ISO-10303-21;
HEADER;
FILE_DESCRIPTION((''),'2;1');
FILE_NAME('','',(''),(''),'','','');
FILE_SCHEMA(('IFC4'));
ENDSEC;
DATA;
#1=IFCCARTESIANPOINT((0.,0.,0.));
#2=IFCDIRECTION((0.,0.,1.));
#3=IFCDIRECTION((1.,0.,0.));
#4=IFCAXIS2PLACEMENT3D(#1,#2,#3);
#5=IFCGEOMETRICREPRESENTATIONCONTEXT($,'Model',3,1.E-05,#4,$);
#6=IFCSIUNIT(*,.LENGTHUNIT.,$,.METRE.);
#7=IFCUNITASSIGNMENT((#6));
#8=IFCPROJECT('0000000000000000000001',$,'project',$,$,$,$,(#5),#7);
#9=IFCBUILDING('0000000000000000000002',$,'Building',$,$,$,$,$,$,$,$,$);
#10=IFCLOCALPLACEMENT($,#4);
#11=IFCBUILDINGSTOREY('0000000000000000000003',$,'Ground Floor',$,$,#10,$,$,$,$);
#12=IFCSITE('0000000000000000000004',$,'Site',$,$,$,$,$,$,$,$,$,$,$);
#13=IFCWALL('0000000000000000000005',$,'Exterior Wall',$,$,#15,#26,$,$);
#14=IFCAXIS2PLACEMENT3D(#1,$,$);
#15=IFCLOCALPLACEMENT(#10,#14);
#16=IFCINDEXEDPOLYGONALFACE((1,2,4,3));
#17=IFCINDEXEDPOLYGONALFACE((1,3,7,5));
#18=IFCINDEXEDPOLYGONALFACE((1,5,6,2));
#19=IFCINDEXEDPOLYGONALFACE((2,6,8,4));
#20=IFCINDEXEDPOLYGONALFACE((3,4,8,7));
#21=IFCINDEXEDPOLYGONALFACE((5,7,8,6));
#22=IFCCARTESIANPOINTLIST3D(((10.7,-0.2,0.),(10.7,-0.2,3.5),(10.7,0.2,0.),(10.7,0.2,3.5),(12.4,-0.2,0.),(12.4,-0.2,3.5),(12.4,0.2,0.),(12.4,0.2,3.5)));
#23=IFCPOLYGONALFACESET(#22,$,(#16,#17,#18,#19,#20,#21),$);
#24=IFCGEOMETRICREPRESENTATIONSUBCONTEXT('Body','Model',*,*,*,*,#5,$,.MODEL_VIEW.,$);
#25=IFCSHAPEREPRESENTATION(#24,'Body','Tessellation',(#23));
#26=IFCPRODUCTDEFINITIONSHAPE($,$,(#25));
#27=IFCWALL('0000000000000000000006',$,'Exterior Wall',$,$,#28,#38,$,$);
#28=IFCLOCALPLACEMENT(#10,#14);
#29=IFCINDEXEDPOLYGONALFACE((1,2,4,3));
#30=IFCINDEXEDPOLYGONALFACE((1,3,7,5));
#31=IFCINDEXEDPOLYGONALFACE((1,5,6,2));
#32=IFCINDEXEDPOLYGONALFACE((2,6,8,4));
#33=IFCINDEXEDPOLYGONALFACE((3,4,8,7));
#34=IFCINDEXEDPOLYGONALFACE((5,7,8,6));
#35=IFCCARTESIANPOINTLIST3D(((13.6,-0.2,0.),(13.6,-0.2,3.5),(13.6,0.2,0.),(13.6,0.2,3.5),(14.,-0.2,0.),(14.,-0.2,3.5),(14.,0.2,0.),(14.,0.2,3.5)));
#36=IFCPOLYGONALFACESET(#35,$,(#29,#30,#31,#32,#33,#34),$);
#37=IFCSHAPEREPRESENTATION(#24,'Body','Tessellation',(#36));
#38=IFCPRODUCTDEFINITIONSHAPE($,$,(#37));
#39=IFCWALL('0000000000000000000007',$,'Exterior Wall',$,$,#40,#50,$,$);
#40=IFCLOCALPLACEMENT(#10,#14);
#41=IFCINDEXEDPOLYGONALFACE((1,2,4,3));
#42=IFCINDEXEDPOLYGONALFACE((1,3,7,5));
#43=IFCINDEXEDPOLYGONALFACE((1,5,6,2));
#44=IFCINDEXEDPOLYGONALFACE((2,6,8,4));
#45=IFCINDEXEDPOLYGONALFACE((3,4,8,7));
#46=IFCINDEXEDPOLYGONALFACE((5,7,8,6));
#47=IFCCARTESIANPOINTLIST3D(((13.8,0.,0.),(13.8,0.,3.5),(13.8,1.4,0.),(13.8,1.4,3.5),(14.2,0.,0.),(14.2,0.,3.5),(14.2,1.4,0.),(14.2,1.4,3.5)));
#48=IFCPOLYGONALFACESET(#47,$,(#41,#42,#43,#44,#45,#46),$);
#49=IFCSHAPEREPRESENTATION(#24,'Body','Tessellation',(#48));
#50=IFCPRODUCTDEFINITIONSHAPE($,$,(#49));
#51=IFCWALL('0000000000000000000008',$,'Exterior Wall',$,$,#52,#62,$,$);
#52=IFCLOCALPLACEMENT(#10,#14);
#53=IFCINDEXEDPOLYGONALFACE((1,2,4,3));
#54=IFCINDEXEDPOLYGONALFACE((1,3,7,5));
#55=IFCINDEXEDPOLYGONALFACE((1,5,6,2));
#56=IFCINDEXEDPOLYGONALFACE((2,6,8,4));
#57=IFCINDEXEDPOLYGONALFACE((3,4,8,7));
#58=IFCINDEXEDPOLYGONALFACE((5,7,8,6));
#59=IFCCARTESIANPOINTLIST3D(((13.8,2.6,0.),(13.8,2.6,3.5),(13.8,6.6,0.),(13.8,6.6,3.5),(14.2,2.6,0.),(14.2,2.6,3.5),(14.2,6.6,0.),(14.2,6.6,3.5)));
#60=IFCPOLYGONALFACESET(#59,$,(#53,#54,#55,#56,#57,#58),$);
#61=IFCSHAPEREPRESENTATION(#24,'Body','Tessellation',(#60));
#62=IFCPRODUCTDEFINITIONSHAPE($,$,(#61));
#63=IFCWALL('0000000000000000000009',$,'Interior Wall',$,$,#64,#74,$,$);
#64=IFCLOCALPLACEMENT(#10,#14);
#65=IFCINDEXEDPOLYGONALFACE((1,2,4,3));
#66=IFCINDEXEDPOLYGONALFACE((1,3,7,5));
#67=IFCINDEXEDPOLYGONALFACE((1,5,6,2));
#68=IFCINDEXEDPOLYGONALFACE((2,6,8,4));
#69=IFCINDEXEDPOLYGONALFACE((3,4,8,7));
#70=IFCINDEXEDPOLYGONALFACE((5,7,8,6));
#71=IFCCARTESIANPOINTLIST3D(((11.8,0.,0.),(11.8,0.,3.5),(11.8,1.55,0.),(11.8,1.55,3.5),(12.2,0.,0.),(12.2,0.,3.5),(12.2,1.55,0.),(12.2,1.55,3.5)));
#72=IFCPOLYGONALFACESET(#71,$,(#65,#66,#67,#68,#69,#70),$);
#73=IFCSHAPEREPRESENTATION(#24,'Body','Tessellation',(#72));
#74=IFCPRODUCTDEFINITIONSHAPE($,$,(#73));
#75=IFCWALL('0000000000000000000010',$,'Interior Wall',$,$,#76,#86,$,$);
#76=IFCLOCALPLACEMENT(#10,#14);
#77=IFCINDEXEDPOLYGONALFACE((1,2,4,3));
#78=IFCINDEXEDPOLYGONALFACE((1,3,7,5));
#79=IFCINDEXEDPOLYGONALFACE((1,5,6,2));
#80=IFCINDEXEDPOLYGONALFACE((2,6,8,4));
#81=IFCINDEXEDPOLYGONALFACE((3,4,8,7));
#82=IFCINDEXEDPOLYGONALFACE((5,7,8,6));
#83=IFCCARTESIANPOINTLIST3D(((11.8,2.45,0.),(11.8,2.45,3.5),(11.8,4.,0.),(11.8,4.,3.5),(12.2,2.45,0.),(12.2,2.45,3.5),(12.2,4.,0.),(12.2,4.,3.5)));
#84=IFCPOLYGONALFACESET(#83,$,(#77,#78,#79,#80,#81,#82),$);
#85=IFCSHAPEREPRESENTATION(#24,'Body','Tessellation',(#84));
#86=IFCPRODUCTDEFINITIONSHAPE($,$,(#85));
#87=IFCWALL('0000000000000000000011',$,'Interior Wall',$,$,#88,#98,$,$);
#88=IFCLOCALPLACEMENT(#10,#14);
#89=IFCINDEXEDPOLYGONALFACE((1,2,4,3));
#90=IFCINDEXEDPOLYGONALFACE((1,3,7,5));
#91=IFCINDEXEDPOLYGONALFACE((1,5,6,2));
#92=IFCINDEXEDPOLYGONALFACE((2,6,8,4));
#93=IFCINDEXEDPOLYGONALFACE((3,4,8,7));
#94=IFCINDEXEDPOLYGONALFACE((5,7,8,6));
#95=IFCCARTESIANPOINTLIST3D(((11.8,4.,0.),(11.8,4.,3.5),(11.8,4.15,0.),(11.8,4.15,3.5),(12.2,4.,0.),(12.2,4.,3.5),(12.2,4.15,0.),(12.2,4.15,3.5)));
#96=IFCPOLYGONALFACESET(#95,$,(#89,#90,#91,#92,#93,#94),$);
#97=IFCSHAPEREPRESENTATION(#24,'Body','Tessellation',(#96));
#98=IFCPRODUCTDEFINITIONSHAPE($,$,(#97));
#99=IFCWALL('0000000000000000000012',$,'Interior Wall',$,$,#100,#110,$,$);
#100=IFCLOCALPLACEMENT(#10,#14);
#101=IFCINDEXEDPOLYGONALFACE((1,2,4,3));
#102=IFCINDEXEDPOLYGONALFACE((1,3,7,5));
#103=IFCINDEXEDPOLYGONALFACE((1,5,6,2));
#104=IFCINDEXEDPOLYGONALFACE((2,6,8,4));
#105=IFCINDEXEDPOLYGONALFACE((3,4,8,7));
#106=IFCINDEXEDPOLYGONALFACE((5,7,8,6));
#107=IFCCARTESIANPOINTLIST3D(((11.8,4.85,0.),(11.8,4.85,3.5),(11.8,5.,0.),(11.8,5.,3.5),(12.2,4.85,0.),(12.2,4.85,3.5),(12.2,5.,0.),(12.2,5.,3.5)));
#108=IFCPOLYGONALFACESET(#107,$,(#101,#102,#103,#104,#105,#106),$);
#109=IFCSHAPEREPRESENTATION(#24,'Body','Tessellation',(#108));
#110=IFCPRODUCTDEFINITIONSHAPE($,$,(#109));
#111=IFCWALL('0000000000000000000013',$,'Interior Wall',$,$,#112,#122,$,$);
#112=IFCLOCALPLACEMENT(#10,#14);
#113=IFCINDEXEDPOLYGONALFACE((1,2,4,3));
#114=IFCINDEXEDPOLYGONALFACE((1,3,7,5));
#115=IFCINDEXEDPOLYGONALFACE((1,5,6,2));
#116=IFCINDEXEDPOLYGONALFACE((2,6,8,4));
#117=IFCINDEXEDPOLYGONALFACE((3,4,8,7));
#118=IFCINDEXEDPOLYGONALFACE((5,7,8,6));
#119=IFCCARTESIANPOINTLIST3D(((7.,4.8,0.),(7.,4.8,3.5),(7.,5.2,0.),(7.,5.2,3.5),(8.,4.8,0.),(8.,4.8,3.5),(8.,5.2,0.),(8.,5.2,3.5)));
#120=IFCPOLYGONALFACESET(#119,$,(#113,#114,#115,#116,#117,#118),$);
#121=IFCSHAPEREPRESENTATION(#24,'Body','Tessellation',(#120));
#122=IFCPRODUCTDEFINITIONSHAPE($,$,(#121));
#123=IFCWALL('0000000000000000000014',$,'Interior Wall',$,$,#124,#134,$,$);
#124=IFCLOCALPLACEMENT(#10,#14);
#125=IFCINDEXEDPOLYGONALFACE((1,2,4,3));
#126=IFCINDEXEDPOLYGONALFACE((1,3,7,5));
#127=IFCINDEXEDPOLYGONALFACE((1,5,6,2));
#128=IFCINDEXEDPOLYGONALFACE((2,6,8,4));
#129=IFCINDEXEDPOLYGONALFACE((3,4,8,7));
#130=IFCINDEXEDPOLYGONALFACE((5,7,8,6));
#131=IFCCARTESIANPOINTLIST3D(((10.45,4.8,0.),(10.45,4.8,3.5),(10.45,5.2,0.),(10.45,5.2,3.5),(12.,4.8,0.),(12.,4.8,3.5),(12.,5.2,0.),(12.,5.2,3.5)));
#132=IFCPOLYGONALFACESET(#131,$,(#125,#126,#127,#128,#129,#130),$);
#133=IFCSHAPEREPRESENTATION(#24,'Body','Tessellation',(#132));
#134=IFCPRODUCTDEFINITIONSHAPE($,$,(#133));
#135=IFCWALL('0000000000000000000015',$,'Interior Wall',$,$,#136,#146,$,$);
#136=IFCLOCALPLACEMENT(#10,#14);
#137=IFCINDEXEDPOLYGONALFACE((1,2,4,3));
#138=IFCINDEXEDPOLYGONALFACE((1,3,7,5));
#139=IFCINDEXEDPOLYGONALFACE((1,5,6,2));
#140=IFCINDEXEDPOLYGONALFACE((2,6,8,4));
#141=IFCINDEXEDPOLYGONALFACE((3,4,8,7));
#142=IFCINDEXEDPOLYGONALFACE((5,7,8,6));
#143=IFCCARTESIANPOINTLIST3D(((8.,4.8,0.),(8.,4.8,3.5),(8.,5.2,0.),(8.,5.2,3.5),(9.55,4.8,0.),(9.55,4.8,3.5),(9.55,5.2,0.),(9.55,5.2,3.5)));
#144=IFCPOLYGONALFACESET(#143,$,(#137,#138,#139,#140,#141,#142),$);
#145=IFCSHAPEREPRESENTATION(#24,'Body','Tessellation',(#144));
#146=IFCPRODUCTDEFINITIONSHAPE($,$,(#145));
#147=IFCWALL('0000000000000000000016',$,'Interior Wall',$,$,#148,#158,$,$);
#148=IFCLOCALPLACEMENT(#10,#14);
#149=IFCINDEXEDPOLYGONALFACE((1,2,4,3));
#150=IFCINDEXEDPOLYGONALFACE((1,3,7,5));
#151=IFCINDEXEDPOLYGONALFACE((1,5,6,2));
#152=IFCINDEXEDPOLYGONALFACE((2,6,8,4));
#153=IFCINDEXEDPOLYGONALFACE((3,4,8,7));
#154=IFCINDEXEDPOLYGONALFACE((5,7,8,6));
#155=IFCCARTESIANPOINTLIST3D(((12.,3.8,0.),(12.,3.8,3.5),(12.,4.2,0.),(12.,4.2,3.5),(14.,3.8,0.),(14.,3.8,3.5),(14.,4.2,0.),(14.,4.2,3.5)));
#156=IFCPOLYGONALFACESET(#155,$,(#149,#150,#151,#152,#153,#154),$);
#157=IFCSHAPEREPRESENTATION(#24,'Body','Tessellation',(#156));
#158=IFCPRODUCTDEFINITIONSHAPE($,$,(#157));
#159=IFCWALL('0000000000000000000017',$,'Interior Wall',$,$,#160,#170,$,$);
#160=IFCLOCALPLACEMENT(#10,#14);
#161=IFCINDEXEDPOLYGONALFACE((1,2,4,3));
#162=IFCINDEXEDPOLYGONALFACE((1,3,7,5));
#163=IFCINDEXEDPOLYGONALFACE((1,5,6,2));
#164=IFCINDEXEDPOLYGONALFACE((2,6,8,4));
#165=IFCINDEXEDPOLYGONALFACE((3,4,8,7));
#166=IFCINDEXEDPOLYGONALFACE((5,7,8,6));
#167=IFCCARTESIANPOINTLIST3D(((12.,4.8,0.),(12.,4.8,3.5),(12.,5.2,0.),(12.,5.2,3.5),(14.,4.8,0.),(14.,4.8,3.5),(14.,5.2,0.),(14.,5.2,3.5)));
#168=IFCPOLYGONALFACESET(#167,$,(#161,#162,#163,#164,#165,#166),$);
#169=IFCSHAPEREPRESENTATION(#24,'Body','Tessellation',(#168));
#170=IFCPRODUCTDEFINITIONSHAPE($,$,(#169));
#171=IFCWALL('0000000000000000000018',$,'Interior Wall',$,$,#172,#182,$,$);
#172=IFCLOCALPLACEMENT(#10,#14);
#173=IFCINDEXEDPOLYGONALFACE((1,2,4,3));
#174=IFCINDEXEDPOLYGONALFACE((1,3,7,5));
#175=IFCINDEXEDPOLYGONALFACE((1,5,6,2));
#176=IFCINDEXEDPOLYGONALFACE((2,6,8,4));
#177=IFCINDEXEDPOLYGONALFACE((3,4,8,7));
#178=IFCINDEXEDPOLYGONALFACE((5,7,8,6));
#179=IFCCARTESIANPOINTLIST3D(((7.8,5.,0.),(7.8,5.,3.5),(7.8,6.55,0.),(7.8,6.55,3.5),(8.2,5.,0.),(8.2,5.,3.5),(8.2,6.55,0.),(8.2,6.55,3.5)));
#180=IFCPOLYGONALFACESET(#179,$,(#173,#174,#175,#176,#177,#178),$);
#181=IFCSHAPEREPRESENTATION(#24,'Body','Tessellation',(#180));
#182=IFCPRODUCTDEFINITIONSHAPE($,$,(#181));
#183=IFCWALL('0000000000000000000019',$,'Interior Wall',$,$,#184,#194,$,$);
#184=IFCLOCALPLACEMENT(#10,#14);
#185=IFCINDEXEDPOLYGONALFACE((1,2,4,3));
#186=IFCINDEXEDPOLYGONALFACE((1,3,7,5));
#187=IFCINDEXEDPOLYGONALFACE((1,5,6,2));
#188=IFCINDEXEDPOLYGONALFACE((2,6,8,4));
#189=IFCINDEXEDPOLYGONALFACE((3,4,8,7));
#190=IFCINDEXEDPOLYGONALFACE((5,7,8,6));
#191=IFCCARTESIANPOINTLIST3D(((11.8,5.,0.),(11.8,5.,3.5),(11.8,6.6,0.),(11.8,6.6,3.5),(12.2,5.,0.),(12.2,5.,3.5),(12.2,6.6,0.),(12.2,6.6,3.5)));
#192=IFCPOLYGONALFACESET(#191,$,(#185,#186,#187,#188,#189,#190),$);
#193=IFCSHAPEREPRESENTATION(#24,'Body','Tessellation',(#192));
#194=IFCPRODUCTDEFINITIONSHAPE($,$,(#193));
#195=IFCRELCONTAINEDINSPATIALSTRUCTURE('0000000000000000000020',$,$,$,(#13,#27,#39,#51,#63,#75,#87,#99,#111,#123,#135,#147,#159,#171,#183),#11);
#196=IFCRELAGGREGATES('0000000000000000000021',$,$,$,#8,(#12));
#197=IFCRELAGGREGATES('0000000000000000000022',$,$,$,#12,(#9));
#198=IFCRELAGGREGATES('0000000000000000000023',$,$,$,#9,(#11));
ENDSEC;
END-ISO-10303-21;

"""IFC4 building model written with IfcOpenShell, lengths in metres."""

from ifc_helpers import new_model, si_unit, frame, origin_with_axes, place, context, subcontext, project, spatial, indexed_curve, outline, extrude, element, save


model = new_model("IFC4")

# Units and contexts
model_context = context("Model", 3, precision=1e-05, world=origin_with_axes())
body_context = subcontext(model_context, "Body", "Model", "MODEL_VIEW")
ifc_project = project(units=[si_unit("LENGTHUNIT", "METRE")], contexts=[model_context])

# Site, building, storey
site = spatial("IfcSite", under=ifc_project, Name="Site")
building = spatial("IfcBuilding", under=site, Name="Building")
storey_placement = place(None, origin_with_axes())
storey = spatial("IfcBuildingStorey", under=building, at=storey_placement, Name="Ground Floor")

# Walls
wall_1_placement = place(storey_placement, frame((10.7, 0.0, 0.0), z_axis=(0.0, 0.0, 1.0), x_axis=(1.0, 0.0, 0.0)))
element("IfcWall", 1, at=wall_1_placement, inside=storey, Name="Exterior Wall", context=body_context, shape_type="SweptSolid", body=[
    extrude(outline(indexed_curve([(0.0, 0.0), (0.0, 0.4), (1.7, 0.4), (1.7, 0.0), (0.0, 0.0)], self_intersect=False)), frame((0.0, -0.2, 0.0), z_axis=(0.0, 0.0, 1.0), x_axis=(1.0, 0.0, 0.0)), (0.0, 0.0, 1.0), 3.5),
])
wall_2_placement = place(storey_placement, frame((13.6, 0.0, 0.0), z_axis=(0.0, 0.0, 1.0), x_axis=(1.0, 0.0, 0.0)))
element("IfcWall", 2, at=wall_2_placement, inside=storey, Name="Exterior Wall", context=body_context, shape_type="SweptSolid", body=[
    extrude(outline(indexed_curve([(0.0, 0.0), (0.0, 0.4), (0.4, 0.4), (0.4, 0.0), (0.0, 0.0)], self_intersect=False)), frame((0.0, -0.2, 0.0), z_axis=(0.0, 0.0, 1.0), x_axis=(1.0, 0.0, 0.0)), (0.0, 0.0, 1.0), 3.5),
])
wall_3_placement = place(storey_placement, frame((14.0, 0.0, 0.0), z_axis=(0.0, 0.0, 1.0), x_axis=(0.0, 1.0, 0.0)))
element("IfcWall", 3, at=wall_3_placement, inside=storey, Name="Exterior Wall", context=body_context, shape_type="SweptSolid", body=[
    extrude(outline(indexed_curve([(0.0, 0.0), (0.0, 0.4), (1.4, 0.4), (1.4, 0.0), (0.0, 0.0)], self_intersect=False)), frame((0.0, -0.2, 0.0), z_axis=(0.0, 0.0, 1.0), x_axis=(1.0, 0.0, 0.0)), (0.0, 0.0, 1.0), 3.5),
])
wall_4_placement = place(storey_placement, frame((14.0, 2.6, 0.0), z_axis=(0.0, 0.0, 1.0), x_axis=(0.0, 1.0, 0.0)))
element("IfcWall", 4, at=wall_4_placement, inside=storey, Name="Exterior Wall", context=body_context, shape_type="SweptSolid", body=[
    extrude(outline(indexed_curve([(0.0, 0.0), (0.0, 0.4), (4.0, 0.4), (4.0, 0.0), (0.0, 0.0)], self_intersect=False)), frame((0.0, -0.2, 0.0), z_axis=(0.0, 0.0, 1.0), x_axis=(1.0, 0.0, 0.0)), (0.0, 0.0, 1.0), 3.5),
])
wall_5_placement = place(storey_placement, frame((12.0, 0.0, 0.0), z_axis=(0.0, 0.0, 1.0), x_axis=(0.0, 1.0, 0.0)))
element("IfcWall", 5, at=wall_5_placement, inside=storey, Name="Interior Wall", context=body_context, shape_type="SweptSolid", body=[
    extrude(outline(indexed_curve([(0.0, 0.0), (0.0, 0.4), (1.55, 0.4), (1.55, 0.0), (0.0, 0.0)], self_intersect=False)), frame((0.0, -0.2, 0.0), z_axis=(0.0, 0.0, 1.0), x_axis=(1.0, 0.0, 0.0)), (0.0, 0.0, 1.0), 3.5),
])
wall_6_placement = place(storey_placement, frame((12.0, 2.45, 0.0), z_axis=(0.0, 0.0, 1.0), x_axis=(0.0, 1.0, 0.0)))
element("IfcWall", 6, at=wall_6_placement, inside=storey, Name="Interior Wall", context=body_context, shape_type="SweptSolid", body=[
    extrude(outline(indexed_curve([(0.0, 0.0), (0.0, 0.4), (1.55, 0.4), (1.55, 0.0), (0.0, 0.0)], self_intersect=False)), frame((0.0, -0.2, 0.0), z_axis=(0.0, 0.0, 1.0), x_axis=(1.0, 0.0, 0.0)), (0.0, 0.0, 1.0), 3.5),
])
for number, where, z_axis, x_axis, name in (
    (7, (12.0, 4.0, 0.0), (0.0, 0.0, 1.0), (0.0, 1.0, 0.0), "Interior Wall"),
    (8, (12.0, 4.85, 0.0), (0.0, 0.0, 1.0), (0.0, 1.0, 0.0), "Interior Wall"),
):
    element("IfcWall", number, at=place(storey_placement, frame(where, z_axis=z_axis, x_axis=x_axis)), inside=storey, Name=name, context=body_context, shape_type="SweptSolid", body=[
        extrude(outline(indexed_curve([(0.0, 0.0), (0.0, 0.4), (0.15, 0.4), (0.15, 0.0), (0.0, 0.0)], self_intersect=False)), frame((0.0, -0.2, 0.0), z_axis=(0.0, 0.0, 1.0), x_axis=(1.0, 0.0, 0.0)), (0.0, 0.0, 1.0), 3.5),
    ])
wall_7_placement = place(storey_placement, frame((8.0, 5.0, 0.0), z_axis=(0.0, 0.0, 1.0), x_axis=(-1.0, 0.0, 0.0)))
element("IfcWall", 9, at=wall_7_placement, inside=storey, Name="Interior Wall", context=body_context, shape_type="SweptSolid", body=[
    extrude(outline(indexed_curve([(0.0, 0.0), (0.0, 0.4), (1.0, 0.4), (1.0, 0.0), (0.0, 0.0)], self_intersect=False)), frame((0.0, -0.2, 0.0), z_axis=(0.0, 0.0, 1.0), x_axis=(1.0, 0.0, 0.0)), (0.0, 0.0, 1.0), 3.5),
])
for number, where, z_axis, x_axis, name in (
    (10, (12.0, 5.0, 0.0), (0.0, 0.0, 1.0), (-1.0, 0.0, 0.0), "Interior Wall"),
    (11, (9.55, 5.0, 0.0), (0.0, 0.0, 1.0), (-1.0, 0.0, 0.0), "Interior Wall"),
):
    element("IfcWall", number, at=place(storey_placement, frame(where, z_axis=z_axis, x_axis=x_axis)), inside=storey, Name=name, context=body_context, shape_type="SweptSolid", body=[
        extrude(outline(indexed_curve([(0.0, 0.0), (0.0, 0.4), (1.55, 0.4), (1.55, 0.0), (0.0, 0.0)], self_intersect=False)), frame((0.0, -0.2, 0.0), z_axis=(0.0, 0.0, 1.0), x_axis=(1.0, 0.0, 0.0)), (0.0, 0.0, 1.0), 3.5),
    ])
for number, where, z_axis, x_axis, name in (
    (12, (14.0, 4.0, 0.0), (0.0, 0.0, 1.0), (-1.0, 0.0, 0.0), "Interior Wall"),
    (13, (14.0, 5.0, 0.0), (0.0, 0.0, 1.0), (-1.0, 0.0, 0.0), "Interior Wall"),
):
    element("IfcWall", number, at=place(storey_placement, frame(where, z_axis=z_axis, x_axis=x_axis)), inside=storey, Name=name, context=body_context, shape_type="SweptSolid", body=[
        extrude(outline(indexed_curve([(0.0, 0.0), (0.0, 0.4), (2.0, 0.4), (2.0, 0.0), (0.0, 0.0)], self_intersect=False)), frame((0.0, -0.2, 0.0), z_axis=(0.0, 0.0, 1.0), x_axis=(1.0, 0.0, 0.0)), (0.0, 0.0, 1.0), 3.5),
    ])
wall_8_placement = place(storey_placement, frame((8.0, 5.0, 0.0), z_axis=(0.0, 0.0, 1.0), x_axis=(0.0, 1.0, 0.0)))
element("IfcWall", 14, at=wall_8_placement, inside=storey, Name="Interior Wall", context=body_context, shape_type="SweptSolid", body=[
    extrude(outline(indexed_curve([(0.0, 0.0), (0.0, 0.4), (1.55, 0.4), (1.55, 0.0), (0.0, 0.0)], self_intersect=False)), frame((0.0, -0.2, 0.0), z_axis=(0.0, 0.0, 1.0), x_axis=(1.0, 0.0, 0.0)), (0.0, 0.0, 1.0), 3.5),
])
wall_9_placement = place(storey_placement, frame((12.0, 5.0, 0.0), z_axis=(0.0, 0.0, 1.0), x_axis=(0.0, 1.0, 0.0)))
element("IfcWall", 15, at=wall_9_placement, inside=storey, Name="Interior Wall", context=body_context, shape_type="SweptSolid", body=[
    extrude(outline(indexed_curve([(0.0, 0.0), (0.0, 0.4), (1.6, 0.4), (1.6, 0.0), (0.0, 0.0)], self_intersect=False)), frame((0.0, -0.2, 0.0), z_axis=(0.0, 0.0, 1.0), x_axis=(1.0, 0.0, 0.0)), (0.0, 0.0, 1.0), 3.5),
])

save(model, "model.ifc")
